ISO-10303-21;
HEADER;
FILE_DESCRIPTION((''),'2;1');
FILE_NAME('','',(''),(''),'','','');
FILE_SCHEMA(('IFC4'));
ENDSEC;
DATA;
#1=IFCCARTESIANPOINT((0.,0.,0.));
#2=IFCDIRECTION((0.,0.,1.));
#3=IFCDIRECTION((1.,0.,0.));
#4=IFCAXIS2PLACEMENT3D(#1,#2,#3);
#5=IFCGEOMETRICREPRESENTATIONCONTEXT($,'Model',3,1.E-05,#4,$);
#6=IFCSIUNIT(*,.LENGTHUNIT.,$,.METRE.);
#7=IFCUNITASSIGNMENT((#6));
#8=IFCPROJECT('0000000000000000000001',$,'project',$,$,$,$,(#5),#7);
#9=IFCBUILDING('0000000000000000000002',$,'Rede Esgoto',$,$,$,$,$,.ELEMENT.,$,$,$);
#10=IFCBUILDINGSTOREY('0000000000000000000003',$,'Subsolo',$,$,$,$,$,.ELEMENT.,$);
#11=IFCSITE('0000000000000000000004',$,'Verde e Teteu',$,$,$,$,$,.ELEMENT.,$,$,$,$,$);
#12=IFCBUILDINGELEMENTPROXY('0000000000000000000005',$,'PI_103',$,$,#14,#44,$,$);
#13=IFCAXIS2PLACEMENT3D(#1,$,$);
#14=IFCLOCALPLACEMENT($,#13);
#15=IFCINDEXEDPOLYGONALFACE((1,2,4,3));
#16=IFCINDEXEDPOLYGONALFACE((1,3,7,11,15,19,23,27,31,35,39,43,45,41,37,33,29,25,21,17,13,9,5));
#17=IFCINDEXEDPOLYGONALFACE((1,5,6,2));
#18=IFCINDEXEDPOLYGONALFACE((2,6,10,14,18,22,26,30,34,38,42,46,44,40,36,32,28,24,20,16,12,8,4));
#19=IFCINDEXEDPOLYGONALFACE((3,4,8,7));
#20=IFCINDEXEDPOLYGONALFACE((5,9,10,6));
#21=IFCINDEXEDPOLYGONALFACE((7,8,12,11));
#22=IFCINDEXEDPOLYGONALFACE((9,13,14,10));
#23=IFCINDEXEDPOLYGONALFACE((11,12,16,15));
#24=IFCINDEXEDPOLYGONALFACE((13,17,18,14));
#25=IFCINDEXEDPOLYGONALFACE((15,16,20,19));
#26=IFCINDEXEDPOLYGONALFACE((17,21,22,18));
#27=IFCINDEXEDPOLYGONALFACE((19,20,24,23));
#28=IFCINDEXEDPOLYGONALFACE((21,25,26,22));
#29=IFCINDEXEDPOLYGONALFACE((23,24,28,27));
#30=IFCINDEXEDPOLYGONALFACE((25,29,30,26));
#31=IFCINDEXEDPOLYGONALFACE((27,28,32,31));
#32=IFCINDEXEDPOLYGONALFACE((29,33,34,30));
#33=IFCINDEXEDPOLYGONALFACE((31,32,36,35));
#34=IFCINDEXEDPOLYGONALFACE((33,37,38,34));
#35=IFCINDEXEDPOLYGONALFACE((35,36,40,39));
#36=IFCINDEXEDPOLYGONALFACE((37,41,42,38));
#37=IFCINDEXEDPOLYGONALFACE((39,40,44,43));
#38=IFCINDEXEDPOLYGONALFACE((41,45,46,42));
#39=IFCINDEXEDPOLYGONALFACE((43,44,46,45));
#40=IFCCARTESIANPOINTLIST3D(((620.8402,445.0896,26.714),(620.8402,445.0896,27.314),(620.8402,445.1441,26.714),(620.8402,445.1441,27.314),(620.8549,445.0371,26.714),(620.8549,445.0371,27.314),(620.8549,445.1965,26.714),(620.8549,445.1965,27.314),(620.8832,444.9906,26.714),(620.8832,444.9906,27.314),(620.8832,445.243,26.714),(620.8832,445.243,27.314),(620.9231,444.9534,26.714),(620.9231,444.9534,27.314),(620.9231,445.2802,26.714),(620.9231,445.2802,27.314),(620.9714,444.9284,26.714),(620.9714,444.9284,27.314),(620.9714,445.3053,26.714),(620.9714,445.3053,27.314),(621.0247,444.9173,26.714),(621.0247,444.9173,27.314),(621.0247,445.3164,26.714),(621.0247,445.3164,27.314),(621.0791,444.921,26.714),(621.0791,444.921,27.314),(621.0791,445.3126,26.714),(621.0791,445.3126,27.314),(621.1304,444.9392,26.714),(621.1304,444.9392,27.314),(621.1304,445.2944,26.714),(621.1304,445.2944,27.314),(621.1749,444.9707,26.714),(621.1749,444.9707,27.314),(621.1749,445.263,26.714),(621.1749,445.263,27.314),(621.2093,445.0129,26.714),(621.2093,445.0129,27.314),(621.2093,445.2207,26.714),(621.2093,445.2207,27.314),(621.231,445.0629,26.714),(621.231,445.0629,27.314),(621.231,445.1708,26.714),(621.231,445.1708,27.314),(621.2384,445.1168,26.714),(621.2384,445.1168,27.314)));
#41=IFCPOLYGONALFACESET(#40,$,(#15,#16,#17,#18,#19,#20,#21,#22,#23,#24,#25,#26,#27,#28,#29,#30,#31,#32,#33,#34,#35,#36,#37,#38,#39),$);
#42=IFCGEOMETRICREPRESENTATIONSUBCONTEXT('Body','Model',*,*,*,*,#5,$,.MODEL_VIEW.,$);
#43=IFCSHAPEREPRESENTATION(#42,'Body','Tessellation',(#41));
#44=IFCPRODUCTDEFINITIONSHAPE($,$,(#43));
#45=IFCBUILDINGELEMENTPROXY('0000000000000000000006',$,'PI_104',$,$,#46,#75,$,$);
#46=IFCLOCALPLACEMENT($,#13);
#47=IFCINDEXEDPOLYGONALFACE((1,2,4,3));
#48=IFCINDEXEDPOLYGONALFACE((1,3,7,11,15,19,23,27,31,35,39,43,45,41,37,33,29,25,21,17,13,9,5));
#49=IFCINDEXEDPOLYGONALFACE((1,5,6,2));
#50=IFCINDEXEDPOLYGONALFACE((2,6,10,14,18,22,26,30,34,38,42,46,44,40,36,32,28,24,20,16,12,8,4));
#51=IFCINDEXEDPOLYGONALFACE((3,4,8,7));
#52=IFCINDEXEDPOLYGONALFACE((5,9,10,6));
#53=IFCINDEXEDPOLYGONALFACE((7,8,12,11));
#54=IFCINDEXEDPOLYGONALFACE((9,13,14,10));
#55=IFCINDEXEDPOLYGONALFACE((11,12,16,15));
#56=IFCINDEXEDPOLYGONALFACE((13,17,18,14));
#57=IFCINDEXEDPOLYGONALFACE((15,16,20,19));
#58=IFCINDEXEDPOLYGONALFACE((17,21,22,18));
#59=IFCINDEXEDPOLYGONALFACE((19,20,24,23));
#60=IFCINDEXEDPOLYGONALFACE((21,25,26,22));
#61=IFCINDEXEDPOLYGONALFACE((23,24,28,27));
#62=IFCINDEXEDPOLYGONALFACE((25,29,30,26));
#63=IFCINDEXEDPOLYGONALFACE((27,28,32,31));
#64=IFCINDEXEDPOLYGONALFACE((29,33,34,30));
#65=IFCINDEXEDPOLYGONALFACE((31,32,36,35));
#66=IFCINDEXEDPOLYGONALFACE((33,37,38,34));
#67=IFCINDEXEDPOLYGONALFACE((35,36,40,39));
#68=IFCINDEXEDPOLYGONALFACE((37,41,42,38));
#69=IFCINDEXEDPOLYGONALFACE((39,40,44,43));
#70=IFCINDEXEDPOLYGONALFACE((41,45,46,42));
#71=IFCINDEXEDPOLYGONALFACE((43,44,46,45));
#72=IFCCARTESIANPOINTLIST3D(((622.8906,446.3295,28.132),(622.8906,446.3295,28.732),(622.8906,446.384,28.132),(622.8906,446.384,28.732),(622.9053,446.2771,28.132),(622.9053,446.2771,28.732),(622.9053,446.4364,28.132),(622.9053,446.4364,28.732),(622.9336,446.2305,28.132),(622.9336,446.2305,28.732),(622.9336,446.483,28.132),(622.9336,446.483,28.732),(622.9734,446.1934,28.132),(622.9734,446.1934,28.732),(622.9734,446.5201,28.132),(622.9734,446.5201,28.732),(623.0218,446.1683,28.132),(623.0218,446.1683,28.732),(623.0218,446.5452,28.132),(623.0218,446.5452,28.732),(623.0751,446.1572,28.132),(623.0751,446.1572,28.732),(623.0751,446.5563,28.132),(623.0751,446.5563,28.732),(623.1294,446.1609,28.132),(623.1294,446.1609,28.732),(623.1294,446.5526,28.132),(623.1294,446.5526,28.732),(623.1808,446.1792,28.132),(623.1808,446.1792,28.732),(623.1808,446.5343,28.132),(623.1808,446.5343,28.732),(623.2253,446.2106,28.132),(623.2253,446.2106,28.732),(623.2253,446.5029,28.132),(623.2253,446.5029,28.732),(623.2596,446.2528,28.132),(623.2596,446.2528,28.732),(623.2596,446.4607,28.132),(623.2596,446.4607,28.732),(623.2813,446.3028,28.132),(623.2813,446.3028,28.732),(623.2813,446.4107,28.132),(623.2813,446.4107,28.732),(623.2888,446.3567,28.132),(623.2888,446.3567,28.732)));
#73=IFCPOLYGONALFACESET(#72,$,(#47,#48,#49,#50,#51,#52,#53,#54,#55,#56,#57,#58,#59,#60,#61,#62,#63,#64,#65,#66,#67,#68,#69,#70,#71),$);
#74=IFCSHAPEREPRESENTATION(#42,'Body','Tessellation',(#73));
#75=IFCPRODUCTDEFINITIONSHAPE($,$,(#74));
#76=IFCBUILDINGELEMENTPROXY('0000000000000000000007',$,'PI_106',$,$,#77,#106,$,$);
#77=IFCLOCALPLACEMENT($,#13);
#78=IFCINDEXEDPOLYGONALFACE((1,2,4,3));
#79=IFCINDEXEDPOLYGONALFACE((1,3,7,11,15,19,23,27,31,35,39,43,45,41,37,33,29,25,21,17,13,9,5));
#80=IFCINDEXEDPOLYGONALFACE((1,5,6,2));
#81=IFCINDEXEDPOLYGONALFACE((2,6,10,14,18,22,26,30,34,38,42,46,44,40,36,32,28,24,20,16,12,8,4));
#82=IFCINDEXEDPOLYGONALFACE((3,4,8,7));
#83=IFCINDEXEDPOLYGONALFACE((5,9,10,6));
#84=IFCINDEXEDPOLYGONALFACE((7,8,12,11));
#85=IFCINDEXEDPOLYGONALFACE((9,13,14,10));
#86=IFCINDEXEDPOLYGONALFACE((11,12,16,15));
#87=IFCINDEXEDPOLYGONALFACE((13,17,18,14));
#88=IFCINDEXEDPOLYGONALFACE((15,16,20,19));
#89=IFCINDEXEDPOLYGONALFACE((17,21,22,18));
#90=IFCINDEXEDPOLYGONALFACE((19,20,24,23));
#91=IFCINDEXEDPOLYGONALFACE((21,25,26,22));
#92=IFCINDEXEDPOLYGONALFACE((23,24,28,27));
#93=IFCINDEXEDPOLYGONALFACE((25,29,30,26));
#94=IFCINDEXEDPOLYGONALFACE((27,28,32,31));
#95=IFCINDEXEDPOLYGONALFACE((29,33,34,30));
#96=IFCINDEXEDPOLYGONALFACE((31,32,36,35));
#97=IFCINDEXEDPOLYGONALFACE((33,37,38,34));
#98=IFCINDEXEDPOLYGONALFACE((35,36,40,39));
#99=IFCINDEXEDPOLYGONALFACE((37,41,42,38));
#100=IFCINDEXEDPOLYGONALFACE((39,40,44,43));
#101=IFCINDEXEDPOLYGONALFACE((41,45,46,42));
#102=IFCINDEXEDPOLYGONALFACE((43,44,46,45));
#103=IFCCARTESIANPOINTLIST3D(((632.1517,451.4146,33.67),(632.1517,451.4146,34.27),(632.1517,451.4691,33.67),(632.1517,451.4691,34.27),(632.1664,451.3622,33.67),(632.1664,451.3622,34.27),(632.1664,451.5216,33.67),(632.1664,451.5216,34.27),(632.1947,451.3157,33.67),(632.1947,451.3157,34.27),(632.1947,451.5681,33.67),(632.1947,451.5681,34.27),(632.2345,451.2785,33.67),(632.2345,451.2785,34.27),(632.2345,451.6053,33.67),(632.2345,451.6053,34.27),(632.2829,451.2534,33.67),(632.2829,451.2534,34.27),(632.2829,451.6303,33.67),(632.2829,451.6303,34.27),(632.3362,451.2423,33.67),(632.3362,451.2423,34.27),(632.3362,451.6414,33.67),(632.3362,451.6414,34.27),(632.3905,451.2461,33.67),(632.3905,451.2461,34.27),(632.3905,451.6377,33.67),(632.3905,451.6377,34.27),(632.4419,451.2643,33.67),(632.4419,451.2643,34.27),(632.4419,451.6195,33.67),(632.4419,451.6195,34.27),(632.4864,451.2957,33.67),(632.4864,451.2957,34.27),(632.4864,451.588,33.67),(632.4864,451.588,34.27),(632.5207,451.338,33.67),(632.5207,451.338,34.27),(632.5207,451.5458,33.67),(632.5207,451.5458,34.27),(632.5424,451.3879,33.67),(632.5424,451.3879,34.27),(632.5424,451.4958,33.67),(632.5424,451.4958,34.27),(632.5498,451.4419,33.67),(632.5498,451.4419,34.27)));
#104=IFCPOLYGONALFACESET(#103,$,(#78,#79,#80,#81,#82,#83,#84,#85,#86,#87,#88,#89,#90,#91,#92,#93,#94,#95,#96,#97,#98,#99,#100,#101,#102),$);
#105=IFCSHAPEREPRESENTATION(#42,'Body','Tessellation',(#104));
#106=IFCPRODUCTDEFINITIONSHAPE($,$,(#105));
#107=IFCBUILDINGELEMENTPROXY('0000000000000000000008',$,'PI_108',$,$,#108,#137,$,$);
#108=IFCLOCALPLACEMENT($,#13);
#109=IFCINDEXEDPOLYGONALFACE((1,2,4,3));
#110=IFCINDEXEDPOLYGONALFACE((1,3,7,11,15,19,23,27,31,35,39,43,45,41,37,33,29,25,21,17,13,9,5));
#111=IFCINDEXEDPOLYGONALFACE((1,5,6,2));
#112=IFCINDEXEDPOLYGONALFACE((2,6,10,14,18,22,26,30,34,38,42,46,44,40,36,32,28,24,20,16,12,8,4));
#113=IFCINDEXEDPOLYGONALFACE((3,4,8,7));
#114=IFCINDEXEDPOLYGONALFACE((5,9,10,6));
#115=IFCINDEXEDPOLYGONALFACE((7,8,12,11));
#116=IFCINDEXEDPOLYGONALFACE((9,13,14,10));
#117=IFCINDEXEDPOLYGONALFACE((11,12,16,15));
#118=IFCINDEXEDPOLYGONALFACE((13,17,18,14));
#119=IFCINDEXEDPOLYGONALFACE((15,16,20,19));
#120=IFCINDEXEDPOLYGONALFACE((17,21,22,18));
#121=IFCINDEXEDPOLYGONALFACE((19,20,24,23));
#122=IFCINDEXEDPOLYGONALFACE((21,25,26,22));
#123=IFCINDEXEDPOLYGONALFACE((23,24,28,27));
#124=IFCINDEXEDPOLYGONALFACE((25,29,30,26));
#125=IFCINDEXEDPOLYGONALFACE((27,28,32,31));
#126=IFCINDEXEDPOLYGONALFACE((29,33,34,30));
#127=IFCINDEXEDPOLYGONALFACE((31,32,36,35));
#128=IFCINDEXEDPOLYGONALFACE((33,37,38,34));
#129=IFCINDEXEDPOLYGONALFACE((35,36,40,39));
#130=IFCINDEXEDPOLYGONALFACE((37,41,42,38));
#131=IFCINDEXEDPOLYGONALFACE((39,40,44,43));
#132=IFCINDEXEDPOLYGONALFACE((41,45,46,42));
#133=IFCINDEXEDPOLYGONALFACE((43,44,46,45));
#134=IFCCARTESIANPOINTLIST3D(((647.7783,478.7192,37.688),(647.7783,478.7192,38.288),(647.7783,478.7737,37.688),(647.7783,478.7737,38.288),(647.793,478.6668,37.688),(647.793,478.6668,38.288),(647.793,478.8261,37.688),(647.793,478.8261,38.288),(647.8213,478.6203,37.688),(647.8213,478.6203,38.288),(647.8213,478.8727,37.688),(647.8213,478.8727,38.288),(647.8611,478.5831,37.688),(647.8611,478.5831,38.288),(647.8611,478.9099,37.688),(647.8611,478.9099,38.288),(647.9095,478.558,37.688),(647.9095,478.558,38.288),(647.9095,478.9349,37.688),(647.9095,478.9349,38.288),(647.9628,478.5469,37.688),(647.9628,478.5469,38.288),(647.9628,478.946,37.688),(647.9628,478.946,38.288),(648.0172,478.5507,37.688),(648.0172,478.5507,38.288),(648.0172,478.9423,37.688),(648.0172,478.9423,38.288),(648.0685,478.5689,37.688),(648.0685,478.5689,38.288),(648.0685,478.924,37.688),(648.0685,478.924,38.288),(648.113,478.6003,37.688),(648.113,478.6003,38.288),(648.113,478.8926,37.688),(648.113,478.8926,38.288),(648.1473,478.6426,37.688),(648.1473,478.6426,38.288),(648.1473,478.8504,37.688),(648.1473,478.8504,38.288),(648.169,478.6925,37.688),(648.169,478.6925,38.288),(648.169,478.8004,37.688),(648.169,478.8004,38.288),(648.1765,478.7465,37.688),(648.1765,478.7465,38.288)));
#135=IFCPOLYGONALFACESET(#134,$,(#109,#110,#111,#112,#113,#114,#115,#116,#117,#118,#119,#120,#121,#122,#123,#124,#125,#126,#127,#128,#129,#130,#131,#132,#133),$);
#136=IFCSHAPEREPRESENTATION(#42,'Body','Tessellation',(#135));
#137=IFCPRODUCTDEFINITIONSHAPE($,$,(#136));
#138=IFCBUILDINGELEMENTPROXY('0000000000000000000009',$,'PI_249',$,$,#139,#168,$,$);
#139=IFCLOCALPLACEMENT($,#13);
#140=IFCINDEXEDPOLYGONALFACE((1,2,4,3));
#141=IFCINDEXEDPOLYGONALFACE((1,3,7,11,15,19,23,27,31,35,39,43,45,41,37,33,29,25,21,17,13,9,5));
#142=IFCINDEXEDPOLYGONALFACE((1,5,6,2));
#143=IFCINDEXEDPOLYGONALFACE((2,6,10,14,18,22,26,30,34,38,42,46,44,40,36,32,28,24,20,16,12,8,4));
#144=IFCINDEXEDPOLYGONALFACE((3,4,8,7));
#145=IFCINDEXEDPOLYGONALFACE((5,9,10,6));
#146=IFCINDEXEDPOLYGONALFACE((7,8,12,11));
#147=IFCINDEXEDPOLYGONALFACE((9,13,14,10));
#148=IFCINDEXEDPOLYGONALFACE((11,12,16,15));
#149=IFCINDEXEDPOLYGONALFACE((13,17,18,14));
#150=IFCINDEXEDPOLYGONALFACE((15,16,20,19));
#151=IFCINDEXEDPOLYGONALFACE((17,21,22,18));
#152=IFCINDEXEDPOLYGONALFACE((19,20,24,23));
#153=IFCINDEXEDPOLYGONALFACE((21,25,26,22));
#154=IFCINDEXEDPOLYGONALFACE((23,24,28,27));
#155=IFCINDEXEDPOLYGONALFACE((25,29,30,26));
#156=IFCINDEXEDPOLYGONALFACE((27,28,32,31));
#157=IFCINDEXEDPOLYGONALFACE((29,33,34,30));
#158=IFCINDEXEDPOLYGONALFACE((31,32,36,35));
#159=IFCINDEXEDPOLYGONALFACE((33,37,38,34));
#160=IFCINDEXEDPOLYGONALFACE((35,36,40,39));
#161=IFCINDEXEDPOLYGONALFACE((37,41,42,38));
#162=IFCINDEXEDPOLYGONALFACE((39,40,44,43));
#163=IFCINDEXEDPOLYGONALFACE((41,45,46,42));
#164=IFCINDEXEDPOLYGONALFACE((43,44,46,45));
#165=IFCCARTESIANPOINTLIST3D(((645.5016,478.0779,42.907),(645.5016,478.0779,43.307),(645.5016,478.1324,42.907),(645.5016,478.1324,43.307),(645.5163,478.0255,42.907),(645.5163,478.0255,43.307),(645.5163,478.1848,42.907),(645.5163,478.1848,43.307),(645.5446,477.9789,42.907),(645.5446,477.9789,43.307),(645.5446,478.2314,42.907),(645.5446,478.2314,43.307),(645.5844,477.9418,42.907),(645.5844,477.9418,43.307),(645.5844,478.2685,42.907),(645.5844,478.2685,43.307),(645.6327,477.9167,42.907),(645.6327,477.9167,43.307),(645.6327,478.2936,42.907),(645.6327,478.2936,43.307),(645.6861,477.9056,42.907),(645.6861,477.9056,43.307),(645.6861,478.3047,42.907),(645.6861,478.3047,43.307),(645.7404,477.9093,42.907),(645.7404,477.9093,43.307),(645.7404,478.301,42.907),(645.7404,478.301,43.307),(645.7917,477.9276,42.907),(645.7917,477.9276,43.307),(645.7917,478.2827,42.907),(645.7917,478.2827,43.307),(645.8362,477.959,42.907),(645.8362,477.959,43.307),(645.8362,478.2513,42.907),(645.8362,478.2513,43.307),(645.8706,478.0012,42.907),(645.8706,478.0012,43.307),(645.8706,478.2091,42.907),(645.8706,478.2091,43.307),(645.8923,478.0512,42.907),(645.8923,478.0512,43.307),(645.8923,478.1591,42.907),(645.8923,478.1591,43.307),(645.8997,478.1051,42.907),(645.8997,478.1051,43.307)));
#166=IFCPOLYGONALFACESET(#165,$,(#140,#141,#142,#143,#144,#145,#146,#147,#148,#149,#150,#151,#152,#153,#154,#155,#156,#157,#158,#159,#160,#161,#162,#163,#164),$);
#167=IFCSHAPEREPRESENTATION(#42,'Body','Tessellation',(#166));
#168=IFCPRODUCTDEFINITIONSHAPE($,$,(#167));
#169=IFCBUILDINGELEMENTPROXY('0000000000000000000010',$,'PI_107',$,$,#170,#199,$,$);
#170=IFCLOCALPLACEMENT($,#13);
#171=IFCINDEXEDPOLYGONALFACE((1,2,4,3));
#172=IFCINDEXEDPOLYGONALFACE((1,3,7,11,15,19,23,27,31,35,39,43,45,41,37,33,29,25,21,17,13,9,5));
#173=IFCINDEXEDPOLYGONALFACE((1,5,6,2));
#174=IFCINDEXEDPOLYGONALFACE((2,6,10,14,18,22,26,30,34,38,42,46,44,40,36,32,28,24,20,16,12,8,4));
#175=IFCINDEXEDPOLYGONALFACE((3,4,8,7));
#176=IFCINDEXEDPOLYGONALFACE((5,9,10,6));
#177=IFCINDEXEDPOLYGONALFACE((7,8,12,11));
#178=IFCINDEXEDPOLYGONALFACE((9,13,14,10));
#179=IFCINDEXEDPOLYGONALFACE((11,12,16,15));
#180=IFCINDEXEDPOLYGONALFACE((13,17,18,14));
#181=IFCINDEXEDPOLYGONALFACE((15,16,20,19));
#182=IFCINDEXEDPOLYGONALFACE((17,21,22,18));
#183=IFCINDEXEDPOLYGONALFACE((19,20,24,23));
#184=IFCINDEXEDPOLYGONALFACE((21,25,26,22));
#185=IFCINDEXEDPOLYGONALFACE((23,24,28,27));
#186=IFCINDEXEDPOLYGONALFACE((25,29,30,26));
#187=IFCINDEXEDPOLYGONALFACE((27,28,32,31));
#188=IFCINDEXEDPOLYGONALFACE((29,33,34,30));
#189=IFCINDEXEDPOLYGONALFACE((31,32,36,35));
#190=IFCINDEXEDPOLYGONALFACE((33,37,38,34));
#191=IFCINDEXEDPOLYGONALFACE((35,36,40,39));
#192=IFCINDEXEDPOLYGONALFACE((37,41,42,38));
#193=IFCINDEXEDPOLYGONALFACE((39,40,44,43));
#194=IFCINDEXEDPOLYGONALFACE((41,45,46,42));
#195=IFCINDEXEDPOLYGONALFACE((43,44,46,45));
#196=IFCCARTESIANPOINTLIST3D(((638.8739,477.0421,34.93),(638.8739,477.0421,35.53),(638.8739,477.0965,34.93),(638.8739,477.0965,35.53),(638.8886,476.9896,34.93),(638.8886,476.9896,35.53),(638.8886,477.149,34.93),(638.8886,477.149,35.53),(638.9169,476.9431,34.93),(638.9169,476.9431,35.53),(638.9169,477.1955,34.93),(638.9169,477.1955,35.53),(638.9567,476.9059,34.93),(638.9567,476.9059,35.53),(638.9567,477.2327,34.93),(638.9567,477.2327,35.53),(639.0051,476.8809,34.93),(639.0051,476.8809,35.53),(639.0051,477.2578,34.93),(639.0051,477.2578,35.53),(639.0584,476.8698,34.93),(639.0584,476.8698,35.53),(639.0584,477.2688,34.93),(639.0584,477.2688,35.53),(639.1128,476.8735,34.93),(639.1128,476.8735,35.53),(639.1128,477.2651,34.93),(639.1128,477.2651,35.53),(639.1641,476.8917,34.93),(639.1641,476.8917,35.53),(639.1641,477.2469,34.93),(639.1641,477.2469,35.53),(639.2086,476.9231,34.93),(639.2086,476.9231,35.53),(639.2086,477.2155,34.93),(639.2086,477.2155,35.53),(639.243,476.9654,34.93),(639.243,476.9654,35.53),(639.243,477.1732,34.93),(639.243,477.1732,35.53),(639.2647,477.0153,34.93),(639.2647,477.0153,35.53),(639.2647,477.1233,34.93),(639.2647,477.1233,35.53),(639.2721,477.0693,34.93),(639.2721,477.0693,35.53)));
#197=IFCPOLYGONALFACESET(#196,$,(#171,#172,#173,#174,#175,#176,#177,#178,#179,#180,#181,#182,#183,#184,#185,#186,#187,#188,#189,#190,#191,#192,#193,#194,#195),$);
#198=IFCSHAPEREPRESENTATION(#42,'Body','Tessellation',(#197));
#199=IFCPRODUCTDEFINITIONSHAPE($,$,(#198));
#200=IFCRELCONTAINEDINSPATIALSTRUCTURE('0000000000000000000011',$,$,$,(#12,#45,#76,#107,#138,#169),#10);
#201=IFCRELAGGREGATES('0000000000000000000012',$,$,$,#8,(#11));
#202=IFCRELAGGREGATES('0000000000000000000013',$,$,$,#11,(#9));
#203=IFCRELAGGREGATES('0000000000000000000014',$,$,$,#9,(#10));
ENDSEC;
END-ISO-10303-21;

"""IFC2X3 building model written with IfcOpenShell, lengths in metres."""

from ifc_helpers import new_model, si_unit, frame, origin_with_axes, origin_2d, place, context, subcontext, project, spatial, circle, extrude, element, save


model = new_model("IFC2X3")

# Units and contexts
model_context = context("Model", 3, precision=1e-05, world=origin_with_axes())
body_context = subcontext(model_context, "Body", "Model", "MODEL_VIEW")
ifc_project = project(units=[si_unit("LENGTHUNIT", "METRE")], contexts=[model_context])

# Site, building, storey
site = spatial("IfcSite", under=ifc_project, Name="Verde e Teteu", CompositionType="ELEMENT")
building = spatial("IfcBuilding", under=site, Name="Rede Esgoto", CompositionType="ELEMENT")
storey = spatial("IfcBuildingStorey", under=building, Name="Subsolo", CompositionType="ELEMENT")

# Building element proxies
for number, where, z_axis, x_axis, name in (
    (1, (621.0384, 445.1168, 26.714), (0.0, 0.0, 1.0), (1.0, 0.0, 0.0), "PI_103"),
):
    element("IfcBuildingElementProxy", number, at=place(None, frame(where, z_axis=z_axis, x_axis=x_axis)), inside=storey, Name=name, context=body_context, shape_type="SweptSolid", body=[
        extrude(circle(Radius=0.2, at=origin_2d()), origin_with_axes(), (0.0, 0.0, 1.0), 0.6),
    ])
proxy_1_placement = place(None, frame((623.0888, 446.3567, 28.132), z_axis=(0.0, 0.0, 1.0), x_axis=(1.0, 0.0, 0.0)))
element("IfcBuildingElementProxy", 2, at=proxy_1_placement, inside=storey, Name="PI_104", context=body_context, shape_type="SweptSolid", body=[
    extrude(circle(Radius=0.2, at=origin_2d()), origin_with_axes(), (0.0, 0.0, 1.0), 0.6),
])
proxy_2_placement = place(None, frame((632.3498, 451.4419, 33.67), z_axis=(0.0, 0.0, 1.0), x_axis=(1.0, 0.0, 0.0)))
element("IfcBuildingElementProxy", 3, at=proxy_2_placement, inside=storey, Name="PI_106", context=body_context, shape_type="SweptSolid", body=[
    extrude(circle(Radius=0.2, at=origin_2d()), origin_with_axes(), (0.0, 0.0, 1.0), 0.6),
])
proxy_3_placement = place(None, frame((647.9765, 478.7465, 37.688), z_axis=(0.0, 0.0, 1.0), x_axis=(1.0, 0.0, 0.0)))
element("IfcBuildingElementProxy", 4, at=proxy_3_placement, inside=storey, Name="PI_108", context=body_context, shape_type="SweptSolid", body=[
    extrude(circle(Radius=0.2, at=origin_2d()), origin_with_axes(), (0.0, 0.0, 1.0), 0.6),
])
proxy_4_placement = place(None, frame((645.6997, 478.1051, 42.907), z_axis=(0.0, 0.0, 1.0), x_axis=(1.0, 0.0, 0.0)))
element("IfcBuildingElementProxy", 5, at=proxy_4_placement, inside=storey, Name="PI_249", context=body_context, shape_type="SweptSolid", body=[
    extrude(circle(Radius=0.2, at=origin_2d()), origin_with_axes(), (0.0, 0.0, 1.0), 0.4),
])
proxy_5_placement = place(None, frame((639.0721, 477.0693, 34.93), z_axis=(0.0, 0.0, 1.0), x_axis=(1.0, 0.0, 0.0)))
element("IfcBuildingElementProxy", 6, at=proxy_5_placement, inside=storey, Name="PI_107", context=body_context, shape_type="SweptSolid", body=[
    extrude(circle(Radius=0.2, at=origin_2d()), origin_with_axes(), (0.0, 0.0, 1.0), 0.6),
])

save(model, "model.ifc")
